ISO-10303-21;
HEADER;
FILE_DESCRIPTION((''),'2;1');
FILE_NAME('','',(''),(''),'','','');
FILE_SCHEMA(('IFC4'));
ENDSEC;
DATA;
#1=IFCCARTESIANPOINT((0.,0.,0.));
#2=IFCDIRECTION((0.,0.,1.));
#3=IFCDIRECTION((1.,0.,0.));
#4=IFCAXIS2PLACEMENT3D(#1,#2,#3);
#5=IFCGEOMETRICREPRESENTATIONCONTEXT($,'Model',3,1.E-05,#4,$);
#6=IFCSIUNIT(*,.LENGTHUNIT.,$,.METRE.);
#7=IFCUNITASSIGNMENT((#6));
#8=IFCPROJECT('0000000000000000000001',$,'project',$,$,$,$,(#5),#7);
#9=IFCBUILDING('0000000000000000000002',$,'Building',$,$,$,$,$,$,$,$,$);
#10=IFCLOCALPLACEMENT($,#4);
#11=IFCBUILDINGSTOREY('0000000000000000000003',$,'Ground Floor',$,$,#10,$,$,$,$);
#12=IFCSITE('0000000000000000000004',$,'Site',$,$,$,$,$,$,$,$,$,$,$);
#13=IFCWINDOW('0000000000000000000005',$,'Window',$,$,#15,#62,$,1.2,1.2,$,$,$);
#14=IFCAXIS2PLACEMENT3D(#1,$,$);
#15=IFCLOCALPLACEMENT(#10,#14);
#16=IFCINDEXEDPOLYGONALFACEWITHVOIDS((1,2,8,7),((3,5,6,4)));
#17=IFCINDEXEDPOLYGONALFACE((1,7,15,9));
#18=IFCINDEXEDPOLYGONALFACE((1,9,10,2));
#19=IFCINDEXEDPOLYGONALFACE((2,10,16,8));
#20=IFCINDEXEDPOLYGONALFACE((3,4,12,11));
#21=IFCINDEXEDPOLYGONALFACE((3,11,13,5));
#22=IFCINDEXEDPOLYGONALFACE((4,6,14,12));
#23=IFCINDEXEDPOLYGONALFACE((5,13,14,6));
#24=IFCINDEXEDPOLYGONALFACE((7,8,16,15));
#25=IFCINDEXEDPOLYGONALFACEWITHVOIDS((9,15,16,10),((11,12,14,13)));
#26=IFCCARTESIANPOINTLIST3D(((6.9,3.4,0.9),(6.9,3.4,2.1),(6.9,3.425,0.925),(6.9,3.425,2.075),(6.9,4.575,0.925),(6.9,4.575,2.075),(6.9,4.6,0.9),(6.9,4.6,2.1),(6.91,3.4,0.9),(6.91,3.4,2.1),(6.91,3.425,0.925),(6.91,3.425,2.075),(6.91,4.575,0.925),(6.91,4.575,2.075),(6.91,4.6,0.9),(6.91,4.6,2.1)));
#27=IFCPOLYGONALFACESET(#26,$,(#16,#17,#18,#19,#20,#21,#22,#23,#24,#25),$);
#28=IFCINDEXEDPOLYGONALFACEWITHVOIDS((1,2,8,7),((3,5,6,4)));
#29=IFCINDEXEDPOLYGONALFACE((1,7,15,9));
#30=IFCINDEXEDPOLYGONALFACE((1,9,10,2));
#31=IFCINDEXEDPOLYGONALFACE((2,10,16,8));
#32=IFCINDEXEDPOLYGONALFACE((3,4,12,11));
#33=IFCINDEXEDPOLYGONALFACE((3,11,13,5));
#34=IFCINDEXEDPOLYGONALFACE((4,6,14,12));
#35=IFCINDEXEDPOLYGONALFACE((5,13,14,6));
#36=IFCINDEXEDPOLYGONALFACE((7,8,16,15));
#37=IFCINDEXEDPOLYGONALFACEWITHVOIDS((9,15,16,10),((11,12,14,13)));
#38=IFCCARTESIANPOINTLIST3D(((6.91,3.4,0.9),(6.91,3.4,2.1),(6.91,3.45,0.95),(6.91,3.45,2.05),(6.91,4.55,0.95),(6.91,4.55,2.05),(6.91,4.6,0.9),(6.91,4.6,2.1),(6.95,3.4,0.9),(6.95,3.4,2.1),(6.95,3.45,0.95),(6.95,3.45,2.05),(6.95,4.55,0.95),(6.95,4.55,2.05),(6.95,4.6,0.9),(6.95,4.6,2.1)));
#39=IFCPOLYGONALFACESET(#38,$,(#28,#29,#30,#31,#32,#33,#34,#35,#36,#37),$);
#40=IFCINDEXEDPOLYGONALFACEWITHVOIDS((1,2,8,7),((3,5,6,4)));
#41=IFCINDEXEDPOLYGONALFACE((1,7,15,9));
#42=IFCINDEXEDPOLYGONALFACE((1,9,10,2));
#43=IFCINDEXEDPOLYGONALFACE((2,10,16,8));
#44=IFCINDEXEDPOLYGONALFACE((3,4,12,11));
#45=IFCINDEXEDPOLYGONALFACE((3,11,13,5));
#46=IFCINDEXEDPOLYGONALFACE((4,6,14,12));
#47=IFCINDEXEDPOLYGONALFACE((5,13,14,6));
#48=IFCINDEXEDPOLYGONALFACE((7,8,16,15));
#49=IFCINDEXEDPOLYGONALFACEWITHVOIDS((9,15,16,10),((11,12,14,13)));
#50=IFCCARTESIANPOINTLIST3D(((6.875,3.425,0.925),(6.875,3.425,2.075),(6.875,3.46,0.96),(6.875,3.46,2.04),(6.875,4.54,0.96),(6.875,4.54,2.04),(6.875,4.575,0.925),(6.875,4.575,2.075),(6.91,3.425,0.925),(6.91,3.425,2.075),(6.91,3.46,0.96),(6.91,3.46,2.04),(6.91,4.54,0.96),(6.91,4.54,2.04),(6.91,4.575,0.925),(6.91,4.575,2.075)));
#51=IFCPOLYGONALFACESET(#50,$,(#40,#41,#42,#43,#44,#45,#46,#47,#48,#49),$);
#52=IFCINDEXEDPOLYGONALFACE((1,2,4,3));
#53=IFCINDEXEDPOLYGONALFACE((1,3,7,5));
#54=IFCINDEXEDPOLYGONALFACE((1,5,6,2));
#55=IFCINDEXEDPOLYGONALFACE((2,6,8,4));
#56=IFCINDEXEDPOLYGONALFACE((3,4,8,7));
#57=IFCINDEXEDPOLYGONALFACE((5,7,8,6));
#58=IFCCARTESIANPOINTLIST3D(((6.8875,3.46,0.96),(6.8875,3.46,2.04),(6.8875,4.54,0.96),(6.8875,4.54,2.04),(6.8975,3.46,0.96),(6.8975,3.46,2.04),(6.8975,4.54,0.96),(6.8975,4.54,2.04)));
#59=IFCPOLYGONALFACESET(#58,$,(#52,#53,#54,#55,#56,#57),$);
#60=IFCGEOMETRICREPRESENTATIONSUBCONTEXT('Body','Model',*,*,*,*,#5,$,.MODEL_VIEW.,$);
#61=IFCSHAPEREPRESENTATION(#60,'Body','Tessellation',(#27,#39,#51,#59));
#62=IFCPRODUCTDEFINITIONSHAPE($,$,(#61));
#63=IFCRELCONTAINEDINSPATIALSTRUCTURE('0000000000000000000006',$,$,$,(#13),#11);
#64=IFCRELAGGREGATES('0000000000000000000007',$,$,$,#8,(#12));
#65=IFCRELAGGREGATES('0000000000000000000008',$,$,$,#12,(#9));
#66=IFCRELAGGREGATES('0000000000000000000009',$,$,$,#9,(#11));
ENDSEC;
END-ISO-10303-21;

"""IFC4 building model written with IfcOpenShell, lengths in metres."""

from ifc_helpers import new_model, si_unit, frame, origin_with_axes, place, context, subcontext, project, spatial, line, indexed_curve, outline, extrude, element, save


model = new_model("IFC4")

# Units and contexts
model_context = context("Model", 3, precision=1e-05, world=origin_with_axes())
body_context = subcontext(model_context, "Body", "Model", "MODEL_VIEW")
ifc_project = project(units=[si_unit("LENGTHUNIT", "METRE")], contexts=[model_context])

# Site, building, storey
site = spatial("IfcSite", under=ifc_project, Name="Site")
building = spatial("IfcBuilding", under=site, Name="Building")
storey_placement = place(None, origin_with_axes())
storey = spatial("IfcBuildingStorey", under=building, at=storey_placement, Name="Ground Floor")

# Window
window_1_placement = place(storey_placement, frame((7.0, 3.4, 0.9), z_axis=(0.0, 0.0, 1.0), x_axis=(0.0, 1.0, 0.0)))
element("IfcWindow", 1, at=window_1_placement, inside=storey, Name="Window", OverallHeight=1.2, OverallWidth=1.2, context=body_context, shape_type="SweptSolid", body=[
    extrude(outline(indexed_curve([(0.0, 0.0), (1.2, 0.0), (1.2, 1.2), (0.0, 1.2)], segments=[line(1, 2, 3, 4, 1)]), holes=[indexed_curve([(0.025, 0.025), (1.175, 0.025), (1.175, 1.175), (0.025, 1.175)], segments=[line(1, 2, 3, 4, 1)])]), frame((0.0, 0.09, 0.0), z_axis=(0.0, -1.0, 0.0), x_axis=(1.0, 0.0, 0.0)), (0.0, 0.0, -1.0), 0.01),
    extrude(outline(indexed_curve([(0.0, 0.0), (1.2, 0.0), (1.2, 1.2), (0.0, 1.2)], segments=[line(1, 2, 3, 4, 1)]), holes=[indexed_curve([(0.05, 0.05), (1.15, 0.05), (1.15, 1.15), (0.05, 1.15)], segments=[line(1, 2, 3, 4, 1)])]), frame((0.0, 0.05, 0.0), z_axis=(0.0, -1.0, 0.0), x_axis=(1.0, 0.0, 0.0)), (0.0, 0.0, -1.0), 0.04),
    extrude(outline(indexed_curve([(0.0, 0.0), (1.15, 0.0), (1.15, 1.15), (0.0, 1.15)], segments=[line(1, 2, 3, 4, 1)]), holes=[indexed_curve([(0.035, 0.035), (1.115, 0.035), (1.115, 1.115), (0.035, 1.115)], segments=[line(1, 2, 3, 4, 1)])]), frame((0.025, 0.09, 0.025), z_axis=(0.0, -1.0, 0.0), x_axis=(1.0, 0.0, 0.0)), (0.0, 0.0, -1.0), 0.035),
    extrude(outline(indexed_curve([(0.035, 0.035), (1.115, 0.035), (1.115, 1.115), (0.035, 1.115)], segments=[line(1, 2, 3, 4, 1)])), frame((0.025, 0.1025, 0.025), z_axis=(0.0, -1.0, 0.0), x_axis=(1.0, 0.0, 0.0)), (0.0, 0.0, -1.0), 0.01),
])

save(model, "model.ifc")
